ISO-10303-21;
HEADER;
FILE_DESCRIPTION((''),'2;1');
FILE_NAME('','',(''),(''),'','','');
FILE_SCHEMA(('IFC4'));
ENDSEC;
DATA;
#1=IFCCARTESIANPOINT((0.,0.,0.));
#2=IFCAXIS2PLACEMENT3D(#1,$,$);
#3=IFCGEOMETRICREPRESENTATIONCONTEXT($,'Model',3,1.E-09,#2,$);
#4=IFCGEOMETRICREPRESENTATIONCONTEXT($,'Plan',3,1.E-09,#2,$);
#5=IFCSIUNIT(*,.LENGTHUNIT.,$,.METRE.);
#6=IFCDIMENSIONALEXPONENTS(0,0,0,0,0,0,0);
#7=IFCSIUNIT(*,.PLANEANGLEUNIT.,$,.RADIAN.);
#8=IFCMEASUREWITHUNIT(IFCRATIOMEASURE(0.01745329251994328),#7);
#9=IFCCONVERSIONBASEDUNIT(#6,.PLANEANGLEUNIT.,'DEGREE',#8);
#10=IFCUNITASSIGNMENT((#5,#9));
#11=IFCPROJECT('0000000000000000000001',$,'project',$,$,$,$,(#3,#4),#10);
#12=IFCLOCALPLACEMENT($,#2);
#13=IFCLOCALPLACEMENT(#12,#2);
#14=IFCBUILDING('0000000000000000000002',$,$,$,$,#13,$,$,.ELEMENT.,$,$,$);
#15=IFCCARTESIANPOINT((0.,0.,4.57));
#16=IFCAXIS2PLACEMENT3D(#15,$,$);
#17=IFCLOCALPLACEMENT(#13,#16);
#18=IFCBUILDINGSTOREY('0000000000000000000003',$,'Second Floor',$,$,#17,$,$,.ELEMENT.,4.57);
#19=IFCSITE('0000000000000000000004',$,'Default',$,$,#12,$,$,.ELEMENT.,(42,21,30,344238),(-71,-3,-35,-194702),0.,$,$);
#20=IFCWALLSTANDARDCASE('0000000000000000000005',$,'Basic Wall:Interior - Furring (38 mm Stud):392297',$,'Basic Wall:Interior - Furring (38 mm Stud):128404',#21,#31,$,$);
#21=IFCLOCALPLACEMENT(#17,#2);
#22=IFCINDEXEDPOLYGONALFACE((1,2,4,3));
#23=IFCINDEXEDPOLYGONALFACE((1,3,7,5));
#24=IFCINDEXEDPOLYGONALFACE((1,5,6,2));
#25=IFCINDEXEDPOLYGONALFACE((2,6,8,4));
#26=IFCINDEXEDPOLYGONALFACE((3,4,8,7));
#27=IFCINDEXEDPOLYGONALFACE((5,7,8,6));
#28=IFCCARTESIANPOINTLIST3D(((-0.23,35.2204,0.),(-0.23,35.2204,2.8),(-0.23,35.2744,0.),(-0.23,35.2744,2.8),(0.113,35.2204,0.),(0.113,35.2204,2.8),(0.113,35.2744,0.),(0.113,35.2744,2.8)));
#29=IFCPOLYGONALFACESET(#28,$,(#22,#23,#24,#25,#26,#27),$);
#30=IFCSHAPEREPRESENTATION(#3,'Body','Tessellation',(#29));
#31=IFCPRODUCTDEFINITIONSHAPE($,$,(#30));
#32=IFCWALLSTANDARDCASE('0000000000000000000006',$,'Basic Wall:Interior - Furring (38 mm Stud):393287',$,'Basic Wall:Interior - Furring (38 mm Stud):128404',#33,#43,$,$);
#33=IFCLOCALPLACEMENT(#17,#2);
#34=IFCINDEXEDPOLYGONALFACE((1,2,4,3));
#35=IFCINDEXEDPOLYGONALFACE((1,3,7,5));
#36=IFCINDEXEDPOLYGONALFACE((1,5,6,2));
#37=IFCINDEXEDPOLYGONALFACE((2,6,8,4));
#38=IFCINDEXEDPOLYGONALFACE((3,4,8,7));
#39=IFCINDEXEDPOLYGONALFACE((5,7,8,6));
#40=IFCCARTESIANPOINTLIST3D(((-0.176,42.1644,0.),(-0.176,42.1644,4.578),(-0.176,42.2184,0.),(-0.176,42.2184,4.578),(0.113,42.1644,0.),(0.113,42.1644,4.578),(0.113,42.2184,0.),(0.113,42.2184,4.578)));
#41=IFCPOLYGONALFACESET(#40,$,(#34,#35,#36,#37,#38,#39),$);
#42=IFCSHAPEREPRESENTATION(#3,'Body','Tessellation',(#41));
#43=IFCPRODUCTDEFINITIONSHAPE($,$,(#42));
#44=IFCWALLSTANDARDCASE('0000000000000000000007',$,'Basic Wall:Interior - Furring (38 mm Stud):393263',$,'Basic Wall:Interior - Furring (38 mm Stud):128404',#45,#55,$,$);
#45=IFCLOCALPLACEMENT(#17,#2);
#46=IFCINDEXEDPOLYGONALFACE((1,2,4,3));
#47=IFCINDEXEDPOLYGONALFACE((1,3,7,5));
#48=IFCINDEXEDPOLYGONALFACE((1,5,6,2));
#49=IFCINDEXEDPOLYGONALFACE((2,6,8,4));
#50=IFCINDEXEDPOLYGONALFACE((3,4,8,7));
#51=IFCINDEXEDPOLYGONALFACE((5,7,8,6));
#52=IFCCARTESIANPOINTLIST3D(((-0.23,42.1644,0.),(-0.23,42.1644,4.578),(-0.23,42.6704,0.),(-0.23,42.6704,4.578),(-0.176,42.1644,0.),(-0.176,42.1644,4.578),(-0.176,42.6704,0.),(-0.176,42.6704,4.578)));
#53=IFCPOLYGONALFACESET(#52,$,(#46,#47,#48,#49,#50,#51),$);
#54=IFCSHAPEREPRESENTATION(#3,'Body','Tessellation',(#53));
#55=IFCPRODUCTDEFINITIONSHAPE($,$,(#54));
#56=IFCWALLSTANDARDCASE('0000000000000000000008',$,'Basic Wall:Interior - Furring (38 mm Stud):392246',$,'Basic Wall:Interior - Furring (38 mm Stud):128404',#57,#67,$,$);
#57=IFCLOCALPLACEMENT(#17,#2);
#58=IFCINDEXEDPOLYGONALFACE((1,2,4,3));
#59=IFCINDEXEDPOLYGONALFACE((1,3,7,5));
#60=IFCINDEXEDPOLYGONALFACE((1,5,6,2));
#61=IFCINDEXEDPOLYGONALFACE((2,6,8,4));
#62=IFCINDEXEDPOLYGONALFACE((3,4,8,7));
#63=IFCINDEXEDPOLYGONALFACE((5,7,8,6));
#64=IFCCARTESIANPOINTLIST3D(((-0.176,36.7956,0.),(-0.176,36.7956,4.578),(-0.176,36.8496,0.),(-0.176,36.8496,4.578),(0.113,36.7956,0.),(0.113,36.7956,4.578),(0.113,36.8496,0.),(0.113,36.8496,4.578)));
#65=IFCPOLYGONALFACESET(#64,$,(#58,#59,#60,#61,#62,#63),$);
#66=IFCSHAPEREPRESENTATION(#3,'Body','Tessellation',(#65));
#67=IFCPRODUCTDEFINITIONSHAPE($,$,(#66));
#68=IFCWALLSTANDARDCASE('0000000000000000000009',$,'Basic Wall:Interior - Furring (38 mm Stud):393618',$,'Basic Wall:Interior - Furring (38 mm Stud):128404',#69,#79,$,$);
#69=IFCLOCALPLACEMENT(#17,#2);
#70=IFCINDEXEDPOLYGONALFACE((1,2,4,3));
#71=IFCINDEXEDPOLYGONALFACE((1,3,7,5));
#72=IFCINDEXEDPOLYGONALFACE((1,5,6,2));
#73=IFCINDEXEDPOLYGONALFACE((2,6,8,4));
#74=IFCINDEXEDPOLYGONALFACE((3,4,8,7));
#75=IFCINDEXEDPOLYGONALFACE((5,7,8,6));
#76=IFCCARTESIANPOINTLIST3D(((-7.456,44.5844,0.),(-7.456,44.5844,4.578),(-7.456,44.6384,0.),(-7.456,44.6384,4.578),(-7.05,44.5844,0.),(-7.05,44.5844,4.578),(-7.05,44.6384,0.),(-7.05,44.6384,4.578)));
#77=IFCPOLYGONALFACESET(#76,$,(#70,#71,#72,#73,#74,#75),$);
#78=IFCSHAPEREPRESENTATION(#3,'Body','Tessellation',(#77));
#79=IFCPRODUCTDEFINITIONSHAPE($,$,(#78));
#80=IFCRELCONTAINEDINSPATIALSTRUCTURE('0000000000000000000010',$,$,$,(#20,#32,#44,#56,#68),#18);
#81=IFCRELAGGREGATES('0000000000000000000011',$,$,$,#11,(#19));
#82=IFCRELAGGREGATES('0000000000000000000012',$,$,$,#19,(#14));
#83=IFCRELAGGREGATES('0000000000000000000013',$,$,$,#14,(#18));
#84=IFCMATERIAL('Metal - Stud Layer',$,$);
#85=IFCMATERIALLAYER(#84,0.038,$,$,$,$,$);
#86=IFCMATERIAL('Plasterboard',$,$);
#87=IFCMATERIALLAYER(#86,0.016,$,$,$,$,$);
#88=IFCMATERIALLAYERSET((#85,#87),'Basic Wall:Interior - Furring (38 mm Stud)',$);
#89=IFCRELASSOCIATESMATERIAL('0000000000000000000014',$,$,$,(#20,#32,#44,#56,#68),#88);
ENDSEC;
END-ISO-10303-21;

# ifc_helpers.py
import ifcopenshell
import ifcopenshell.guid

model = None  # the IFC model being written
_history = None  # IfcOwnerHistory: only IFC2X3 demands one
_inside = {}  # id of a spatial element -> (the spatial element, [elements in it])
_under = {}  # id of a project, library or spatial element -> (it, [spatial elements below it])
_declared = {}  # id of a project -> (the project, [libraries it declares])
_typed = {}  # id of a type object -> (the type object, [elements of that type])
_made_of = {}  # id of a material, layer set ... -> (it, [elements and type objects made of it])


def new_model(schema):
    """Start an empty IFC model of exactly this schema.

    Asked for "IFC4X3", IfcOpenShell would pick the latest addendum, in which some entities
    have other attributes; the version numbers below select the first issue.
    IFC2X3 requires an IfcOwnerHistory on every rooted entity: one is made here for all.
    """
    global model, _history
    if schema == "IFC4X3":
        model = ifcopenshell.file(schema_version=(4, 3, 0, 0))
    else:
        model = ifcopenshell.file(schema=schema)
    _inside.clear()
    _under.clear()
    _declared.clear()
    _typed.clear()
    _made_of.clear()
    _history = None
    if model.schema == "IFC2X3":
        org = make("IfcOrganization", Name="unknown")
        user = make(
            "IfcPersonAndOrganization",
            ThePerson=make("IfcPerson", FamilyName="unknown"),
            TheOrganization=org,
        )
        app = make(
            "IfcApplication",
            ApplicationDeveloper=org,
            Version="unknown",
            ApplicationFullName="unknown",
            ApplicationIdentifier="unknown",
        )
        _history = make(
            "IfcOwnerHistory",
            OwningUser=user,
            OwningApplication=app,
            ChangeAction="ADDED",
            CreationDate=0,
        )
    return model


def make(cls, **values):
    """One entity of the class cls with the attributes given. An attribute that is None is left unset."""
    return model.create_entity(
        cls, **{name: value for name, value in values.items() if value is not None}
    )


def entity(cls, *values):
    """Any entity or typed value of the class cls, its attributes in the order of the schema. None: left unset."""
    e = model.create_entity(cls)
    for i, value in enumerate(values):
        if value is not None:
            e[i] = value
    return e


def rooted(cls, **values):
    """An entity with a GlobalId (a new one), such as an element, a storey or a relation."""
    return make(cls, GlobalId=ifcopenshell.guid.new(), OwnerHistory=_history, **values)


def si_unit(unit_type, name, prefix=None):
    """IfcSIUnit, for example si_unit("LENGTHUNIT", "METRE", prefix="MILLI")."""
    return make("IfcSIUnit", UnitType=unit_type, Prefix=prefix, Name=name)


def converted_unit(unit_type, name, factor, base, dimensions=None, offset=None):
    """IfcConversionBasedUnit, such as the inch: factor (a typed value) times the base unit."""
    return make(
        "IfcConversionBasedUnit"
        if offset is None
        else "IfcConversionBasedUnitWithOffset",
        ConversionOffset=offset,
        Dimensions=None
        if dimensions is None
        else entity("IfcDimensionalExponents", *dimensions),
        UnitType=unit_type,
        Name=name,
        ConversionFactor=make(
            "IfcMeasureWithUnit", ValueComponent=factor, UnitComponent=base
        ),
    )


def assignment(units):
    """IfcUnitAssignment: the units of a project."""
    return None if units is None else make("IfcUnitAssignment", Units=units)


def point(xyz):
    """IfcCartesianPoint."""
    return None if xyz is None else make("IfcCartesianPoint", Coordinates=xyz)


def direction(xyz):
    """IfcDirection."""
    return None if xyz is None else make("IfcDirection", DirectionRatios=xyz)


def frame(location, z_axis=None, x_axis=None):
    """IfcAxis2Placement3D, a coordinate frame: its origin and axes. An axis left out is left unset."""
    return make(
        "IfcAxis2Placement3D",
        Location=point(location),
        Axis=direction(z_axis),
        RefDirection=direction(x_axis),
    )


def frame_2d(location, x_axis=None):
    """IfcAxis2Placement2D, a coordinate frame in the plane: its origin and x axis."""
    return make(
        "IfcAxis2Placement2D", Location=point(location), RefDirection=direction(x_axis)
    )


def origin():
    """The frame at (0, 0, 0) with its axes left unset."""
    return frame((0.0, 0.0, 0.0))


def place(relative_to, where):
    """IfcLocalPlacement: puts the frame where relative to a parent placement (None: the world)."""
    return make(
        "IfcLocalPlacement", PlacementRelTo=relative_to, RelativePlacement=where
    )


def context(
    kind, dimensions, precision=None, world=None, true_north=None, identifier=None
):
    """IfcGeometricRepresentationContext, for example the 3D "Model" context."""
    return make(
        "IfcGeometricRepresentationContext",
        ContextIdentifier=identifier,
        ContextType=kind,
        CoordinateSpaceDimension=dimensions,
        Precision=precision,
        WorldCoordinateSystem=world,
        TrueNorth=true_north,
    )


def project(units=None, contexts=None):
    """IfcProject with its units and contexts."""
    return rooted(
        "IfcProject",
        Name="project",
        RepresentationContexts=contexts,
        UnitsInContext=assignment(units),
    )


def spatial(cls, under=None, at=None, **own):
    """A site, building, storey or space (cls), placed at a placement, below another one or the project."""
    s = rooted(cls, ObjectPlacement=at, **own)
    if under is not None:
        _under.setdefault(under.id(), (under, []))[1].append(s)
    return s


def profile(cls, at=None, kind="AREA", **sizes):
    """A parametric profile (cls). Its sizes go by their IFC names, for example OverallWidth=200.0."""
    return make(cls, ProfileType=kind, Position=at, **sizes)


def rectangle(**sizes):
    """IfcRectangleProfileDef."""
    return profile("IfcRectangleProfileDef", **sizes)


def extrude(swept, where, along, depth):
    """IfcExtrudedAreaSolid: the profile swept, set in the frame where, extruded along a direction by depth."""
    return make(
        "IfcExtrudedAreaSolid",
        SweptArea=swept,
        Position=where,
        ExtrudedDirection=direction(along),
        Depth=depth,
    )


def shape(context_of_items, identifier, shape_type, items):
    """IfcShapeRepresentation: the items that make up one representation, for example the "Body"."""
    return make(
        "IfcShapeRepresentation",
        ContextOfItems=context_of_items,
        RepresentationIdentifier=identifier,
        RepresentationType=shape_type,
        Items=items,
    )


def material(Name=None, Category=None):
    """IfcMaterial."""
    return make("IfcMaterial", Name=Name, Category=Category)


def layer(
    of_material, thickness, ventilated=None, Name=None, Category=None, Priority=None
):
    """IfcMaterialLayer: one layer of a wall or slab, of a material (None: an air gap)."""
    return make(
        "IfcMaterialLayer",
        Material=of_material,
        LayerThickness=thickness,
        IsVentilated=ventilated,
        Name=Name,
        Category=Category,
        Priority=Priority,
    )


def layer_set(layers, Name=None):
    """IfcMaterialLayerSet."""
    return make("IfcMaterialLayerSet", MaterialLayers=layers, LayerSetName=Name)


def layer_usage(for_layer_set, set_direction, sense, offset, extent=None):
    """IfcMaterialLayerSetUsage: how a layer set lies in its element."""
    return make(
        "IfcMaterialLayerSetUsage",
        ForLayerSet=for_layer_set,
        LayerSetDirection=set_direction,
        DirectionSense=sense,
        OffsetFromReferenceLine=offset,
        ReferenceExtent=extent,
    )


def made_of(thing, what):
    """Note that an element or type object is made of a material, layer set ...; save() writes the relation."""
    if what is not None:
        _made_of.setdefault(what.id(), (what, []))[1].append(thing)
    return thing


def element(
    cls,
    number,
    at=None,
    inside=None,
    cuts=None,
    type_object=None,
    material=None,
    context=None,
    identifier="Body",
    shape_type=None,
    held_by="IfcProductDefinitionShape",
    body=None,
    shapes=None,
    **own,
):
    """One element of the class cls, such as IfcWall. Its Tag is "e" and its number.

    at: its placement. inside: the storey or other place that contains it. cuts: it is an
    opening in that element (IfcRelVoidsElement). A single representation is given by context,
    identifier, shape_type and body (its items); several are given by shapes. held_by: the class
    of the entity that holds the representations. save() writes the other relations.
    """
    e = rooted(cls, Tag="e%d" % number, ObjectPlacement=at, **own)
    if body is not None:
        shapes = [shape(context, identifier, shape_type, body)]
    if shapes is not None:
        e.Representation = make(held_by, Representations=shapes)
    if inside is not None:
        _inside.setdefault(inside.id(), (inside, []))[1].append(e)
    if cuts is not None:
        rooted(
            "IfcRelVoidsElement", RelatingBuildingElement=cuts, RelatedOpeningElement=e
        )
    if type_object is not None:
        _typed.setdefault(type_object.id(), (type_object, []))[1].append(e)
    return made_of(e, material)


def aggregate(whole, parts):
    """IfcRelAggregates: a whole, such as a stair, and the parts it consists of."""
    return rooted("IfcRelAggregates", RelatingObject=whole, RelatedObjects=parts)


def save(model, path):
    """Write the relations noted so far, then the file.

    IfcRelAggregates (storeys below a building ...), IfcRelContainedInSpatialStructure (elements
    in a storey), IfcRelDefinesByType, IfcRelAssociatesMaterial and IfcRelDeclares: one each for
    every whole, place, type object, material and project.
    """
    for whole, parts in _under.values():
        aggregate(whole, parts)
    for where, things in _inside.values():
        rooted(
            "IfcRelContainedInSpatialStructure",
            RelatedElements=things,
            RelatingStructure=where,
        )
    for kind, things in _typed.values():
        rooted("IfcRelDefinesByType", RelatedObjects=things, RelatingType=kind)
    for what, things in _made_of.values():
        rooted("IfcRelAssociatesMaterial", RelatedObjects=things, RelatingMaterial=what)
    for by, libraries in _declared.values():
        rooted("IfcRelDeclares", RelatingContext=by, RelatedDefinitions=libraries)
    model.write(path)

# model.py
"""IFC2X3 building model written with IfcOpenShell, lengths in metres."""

from ifc_helpers import new_model, entity, si_unit, converted_unit, frame, frame_2d, origin, place, context, project, spatial, rectangle, extrude, material, layer, layer_set, layer_usage, element, save


model = new_model("IFC2X3")

# Units and contexts
model_context = context("Model", 3, precision=1e-09, world=origin())
plan_context = context("Plan", 3, precision=1e-09, world=origin())
ifc_project = project(units=[si_unit("LENGTHUNIT", "METRE"), converted_unit("PLANEANGLEUNIT", "DEGREE", entity("IfcRatioMeasure", 0.01745329251994328), si_unit("PLANEANGLEUNIT", "RADIAN"), dimensions=[0, 0, 0, 0, 0, 0, 0])], contexts=[model_context, plan_context])

# Site, building, storey
site_placement = place(None, origin())
site = spatial("IfcSite", under=ifc_project, at=site_placement, Name="Default", CompositionType="ELEMENT", RefLatitude=(42, 21, 30, 344238), RefLongitude=(-71, -3, -35, -194702), RefElevation=0.0)
building_placement = place(site_placement, origin())
building = spatial("IfcBuilding", under=site, at=building_placement, CompositionType="ELEMENT")
storey_placement = place(building_placement, frame((0.0, 0.0, 4.57)))
storey = spatial("IfcBuildingStorey", under=building, at=storey_placement, Name="Second Floor", CompositionType="ELEMENT", Elevation=4.57)

# Shared definitions
ifc_material_1 = material(Name="Plasterboard")
ifc_material_2 = material(Name="Metal - Stud Layer")

# Shared definitions
ifc_layer_1 = layer(ifc_material_2, 0.038)
ifc_layer_2 = layer(ifc_material_1, 0.016)
ifc_layer_set_1 = layer_set([ifc_layer_1, ifc_layer_2], Name="Basic Wall:Interior - Furring (38 mm Stud)")
ifc_layer_usage_1 = layer_usage(ifc_layer_set_1, "AXIS2", "NEGATIVE", 0.027)

# Walls
wall_1_placement = place(storey_placement, frame((0.113, 35.2474, 0.0), z_axis=(0.0, 0.0, 1.0), x_axis=(-1.0, 0.0, 0.0)))
element("IfcWallStandardCase", 1, at=wall_1_placement, inside=storey, material=ifc_layer_usage_1, Name="Basic Wall:Interior - Furring (38 mm Stud):392297", ObjectType="Basic Wall:Interior - Furring (38 mm Stud):128404", context=model_context, shape_type="SweptSolid", body=[
    extrude(rectangle(XDim=0.343, YDim=0.054, at=frame_2d((0.1715, 0.0), x_axis=(-1.0, 0.0))), origin(), (0.0, 0.0, 1.0), 2.8),
])
wall_2_placement = place(storey_placement, frame((-0.176, 42.1914, 0.0)))
element("IfcWallStandardCase", 2, at=wall_2_placement, inside=storey, material=ifc_layer_usage_1, Name="Basic Wall:Interior - Furring (38 mm Stud):393287", ObjectType="Basic Wall:Interior - Furring (38 mm Stud):128404", context=model_context, shape_type="SweptSolid", body=[
    extrude(rectangle(XDim=0.289, YDim=0.054, at=frame_2d((0.1445, 0.0), x_axis=(-1.0, 0.0))), origin(), (0.0, 0.0, 1.0), 4.578),
])
wall_3_placement = place(storey_placement, frame((-0.203, 42.6704, 0.0), z_axis=(0.0, 0.0, 1.0), x_axis=(0.0, -1.0, 0.0)))
element("IfcWallStandardCase", 3, at=wall_3_placement, inside=storey, material=ifc_layer_usage_1, Name="Basic Wall:Interior - Furring (38 mm Stud):393263", ObjectType="Basic Wall:Interior - Furring (38 mm Stud):128404", context=model_context, shape_type="SweptSolid", body=[
    extrude(rectangle(XDim=0.506, YDim=0.054, at=frame_2d((0.253, 0.0), x_axis=(-1.0, 0.0))), origin(), (0.0, 0.0, 1.0), 4.578),
])
wall_4_placement = place(storey_placement, frame((-0.176, 36.8226, 0.0)))
element("IfcWallStandardCase", 4, at=wall_4_placement, inside=storey, material=ifc_layer_usage_1, Name="Basic Wall:Interior - Furring (38 mm Stud):392246", ObjectType="Basic Wall:Interior - Furring (38 mm Stud):128404", context=model_context, shape_type="SweptSolid", body=[
    extrude(rectangle(XDim=0.289, YDim=0.054, at=frame_2d((0.1445, 0.0), x_axis=(-1.0, 0.0))), origin(), (0.0, 0.0, 1.0), 4.578),
])
wall_5_placement = place(storey_placement, frame((-7.456, 44.6114, 0.0)))
element("IfcWallStandardCase", 5, at=wall_5_placement, inside=storey, material=ifc_layer_usage_1, Name="Basic Wall:Interior - Furring (38 mm Stud):393618", ObjectType="Basic Wall:Interior - Furring (38 mm Stud):128404", context=model_context, shape_type="SweptSolid", body=[
    extrude(rectangle(XDim=0.406, YDim=0.054, at=frame_2d((0.203, 0.0), x_axis=(-1.0, 0.0))), origin(), (0.0, 0.0, 1.0), 4.578),
])

save(model, "model.ifc")
